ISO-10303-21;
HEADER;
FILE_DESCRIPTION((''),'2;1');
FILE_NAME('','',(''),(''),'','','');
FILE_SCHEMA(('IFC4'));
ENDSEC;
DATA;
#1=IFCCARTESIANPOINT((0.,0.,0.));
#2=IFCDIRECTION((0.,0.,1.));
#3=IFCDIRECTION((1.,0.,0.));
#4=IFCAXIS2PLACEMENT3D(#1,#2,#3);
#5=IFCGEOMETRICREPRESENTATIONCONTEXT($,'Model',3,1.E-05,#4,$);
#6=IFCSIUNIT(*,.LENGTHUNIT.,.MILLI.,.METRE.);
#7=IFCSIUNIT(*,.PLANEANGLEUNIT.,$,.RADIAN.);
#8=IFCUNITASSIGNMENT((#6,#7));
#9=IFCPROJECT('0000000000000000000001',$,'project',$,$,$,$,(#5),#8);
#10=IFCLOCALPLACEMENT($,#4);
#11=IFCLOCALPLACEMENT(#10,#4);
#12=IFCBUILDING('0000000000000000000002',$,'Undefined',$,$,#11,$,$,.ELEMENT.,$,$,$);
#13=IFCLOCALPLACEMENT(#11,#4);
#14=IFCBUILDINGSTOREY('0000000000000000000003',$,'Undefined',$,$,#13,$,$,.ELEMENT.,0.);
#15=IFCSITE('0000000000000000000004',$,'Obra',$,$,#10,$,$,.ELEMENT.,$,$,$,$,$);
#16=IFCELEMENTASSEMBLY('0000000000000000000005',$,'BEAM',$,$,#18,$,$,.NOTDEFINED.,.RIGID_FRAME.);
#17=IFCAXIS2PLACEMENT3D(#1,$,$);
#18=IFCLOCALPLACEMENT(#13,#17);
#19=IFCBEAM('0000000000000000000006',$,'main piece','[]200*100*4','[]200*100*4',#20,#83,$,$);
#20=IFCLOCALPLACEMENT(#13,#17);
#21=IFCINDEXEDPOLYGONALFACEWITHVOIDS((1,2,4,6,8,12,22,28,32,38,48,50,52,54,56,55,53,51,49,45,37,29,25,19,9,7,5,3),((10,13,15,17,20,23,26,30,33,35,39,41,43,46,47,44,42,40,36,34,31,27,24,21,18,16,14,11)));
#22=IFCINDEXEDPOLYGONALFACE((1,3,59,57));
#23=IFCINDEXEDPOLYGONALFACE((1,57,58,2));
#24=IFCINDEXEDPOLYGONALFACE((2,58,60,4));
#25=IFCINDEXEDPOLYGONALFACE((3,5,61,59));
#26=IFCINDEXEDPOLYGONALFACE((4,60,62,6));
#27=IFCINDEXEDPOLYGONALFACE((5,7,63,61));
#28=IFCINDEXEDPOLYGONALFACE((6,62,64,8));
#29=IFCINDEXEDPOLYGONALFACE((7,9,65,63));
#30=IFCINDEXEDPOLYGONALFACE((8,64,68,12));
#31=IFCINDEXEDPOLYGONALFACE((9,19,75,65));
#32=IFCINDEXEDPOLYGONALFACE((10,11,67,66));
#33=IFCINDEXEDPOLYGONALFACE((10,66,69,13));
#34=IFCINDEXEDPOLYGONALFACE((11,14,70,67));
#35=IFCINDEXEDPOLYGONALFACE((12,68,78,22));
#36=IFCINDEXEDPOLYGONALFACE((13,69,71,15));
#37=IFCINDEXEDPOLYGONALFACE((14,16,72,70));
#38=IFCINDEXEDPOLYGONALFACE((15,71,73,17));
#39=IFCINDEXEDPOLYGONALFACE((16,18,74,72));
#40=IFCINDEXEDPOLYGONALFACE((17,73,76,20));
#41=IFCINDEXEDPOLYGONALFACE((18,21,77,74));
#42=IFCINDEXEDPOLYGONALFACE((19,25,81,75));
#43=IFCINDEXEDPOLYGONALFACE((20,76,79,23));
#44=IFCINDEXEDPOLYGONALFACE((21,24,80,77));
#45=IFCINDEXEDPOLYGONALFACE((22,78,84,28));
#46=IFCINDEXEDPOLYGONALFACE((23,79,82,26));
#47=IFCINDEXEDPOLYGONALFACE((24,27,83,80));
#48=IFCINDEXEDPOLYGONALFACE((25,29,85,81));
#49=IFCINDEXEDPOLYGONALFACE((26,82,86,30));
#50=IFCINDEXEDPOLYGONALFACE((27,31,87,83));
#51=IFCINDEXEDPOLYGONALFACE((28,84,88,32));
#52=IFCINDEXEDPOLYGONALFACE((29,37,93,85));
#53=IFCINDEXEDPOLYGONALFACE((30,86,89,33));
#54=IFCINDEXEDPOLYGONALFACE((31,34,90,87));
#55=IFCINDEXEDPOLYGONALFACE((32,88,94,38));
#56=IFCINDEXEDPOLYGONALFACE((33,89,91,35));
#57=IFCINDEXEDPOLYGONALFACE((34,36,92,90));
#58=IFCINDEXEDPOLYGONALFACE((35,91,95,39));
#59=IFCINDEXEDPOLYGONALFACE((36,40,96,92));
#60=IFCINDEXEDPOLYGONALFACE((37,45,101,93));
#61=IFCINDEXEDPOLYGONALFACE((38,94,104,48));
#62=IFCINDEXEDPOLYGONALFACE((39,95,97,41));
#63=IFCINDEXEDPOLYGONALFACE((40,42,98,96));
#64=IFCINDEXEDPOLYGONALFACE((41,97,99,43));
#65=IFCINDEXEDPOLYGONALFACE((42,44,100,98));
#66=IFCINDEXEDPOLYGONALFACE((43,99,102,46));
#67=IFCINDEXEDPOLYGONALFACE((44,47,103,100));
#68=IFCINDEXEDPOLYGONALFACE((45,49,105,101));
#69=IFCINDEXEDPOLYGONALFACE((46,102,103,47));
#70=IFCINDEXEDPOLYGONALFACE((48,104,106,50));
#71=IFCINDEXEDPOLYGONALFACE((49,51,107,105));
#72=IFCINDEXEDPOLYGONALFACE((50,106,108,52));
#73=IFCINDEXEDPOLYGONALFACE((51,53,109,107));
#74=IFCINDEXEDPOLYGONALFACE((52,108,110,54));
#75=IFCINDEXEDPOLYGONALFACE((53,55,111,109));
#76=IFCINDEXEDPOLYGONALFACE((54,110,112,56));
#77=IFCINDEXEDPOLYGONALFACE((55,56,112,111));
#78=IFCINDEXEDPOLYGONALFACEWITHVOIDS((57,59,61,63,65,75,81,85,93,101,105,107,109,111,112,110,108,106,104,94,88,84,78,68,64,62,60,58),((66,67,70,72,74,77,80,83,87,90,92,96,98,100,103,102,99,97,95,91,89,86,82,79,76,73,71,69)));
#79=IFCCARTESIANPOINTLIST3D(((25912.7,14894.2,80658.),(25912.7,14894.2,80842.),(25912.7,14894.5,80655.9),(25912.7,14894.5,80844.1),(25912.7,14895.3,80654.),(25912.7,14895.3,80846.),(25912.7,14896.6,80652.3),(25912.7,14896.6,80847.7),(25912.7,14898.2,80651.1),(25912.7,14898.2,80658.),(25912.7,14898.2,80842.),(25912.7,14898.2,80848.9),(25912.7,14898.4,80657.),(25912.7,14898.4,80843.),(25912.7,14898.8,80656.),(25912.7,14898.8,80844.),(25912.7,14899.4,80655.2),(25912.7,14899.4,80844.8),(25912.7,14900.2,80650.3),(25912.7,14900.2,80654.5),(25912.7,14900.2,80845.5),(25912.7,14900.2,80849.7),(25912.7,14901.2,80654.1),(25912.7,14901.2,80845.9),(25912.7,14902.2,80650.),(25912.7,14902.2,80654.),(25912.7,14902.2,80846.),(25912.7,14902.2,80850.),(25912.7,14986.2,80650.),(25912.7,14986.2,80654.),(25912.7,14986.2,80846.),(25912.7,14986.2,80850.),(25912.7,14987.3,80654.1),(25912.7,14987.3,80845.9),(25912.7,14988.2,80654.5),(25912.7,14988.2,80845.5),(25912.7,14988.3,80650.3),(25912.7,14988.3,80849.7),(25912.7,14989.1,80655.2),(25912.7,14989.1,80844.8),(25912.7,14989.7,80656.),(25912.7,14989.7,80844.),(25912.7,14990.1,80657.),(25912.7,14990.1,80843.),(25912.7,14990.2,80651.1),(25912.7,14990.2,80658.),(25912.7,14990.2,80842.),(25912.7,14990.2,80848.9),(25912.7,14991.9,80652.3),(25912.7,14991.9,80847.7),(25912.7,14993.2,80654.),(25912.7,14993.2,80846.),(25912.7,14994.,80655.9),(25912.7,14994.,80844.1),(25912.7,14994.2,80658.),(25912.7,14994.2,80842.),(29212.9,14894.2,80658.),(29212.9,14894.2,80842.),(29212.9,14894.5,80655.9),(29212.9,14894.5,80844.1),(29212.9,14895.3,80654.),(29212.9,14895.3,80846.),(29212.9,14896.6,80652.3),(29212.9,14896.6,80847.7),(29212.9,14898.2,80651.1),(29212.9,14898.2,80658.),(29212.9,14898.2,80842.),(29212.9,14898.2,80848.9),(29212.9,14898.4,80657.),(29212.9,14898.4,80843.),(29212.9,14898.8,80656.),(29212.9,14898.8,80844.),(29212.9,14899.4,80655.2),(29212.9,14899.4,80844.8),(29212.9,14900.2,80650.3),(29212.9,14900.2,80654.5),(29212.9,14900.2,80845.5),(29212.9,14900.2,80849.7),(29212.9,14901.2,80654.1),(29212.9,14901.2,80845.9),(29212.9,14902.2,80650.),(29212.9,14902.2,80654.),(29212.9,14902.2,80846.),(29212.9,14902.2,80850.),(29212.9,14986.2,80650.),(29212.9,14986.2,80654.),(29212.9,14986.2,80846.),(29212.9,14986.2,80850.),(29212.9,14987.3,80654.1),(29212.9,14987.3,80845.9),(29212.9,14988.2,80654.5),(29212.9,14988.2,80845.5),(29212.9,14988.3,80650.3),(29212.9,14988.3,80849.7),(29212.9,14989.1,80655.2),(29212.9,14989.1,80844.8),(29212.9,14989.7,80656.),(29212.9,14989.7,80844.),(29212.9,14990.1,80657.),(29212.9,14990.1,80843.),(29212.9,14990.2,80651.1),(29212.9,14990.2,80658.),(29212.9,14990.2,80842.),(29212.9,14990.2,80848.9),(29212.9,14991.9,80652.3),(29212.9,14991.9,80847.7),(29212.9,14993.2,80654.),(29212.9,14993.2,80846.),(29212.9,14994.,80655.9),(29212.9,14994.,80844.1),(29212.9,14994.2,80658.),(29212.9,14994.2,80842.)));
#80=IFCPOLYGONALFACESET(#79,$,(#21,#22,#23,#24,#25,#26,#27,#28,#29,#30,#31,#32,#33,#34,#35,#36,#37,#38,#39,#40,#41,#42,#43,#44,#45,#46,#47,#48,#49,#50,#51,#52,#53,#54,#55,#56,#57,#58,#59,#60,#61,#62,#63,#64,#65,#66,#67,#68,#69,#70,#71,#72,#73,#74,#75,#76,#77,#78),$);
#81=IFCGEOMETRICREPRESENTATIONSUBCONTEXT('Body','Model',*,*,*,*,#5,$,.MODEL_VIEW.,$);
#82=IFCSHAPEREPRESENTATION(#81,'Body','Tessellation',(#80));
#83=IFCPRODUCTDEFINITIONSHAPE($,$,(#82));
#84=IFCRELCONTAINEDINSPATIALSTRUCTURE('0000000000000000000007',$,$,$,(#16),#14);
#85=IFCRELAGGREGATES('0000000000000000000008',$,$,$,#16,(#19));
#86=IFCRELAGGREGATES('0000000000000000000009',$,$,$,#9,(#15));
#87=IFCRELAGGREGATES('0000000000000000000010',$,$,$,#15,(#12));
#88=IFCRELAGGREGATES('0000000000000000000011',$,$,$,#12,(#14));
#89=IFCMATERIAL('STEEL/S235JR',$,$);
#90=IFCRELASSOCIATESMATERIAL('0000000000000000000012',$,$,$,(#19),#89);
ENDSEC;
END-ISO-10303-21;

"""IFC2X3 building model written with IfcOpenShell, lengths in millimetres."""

from ifc_helpers import new_model, si_unit, frame, origin_with_axes, origin_2d_with_axis, place, context, subcontext, project, spatial, hollow_rectangle, extrude, material, element, aggregate, save


model = new_model("IFC2X3")

# Units and contexts
model_context = context("Model", 3, precision=1e-05, world=origin_with_axes())
body_context = subcontext(model_context, "Body", "Model", "MODEL_VIEW")
ifc_project = project(units=[si_unit("LENGTHUNIT", "METRE", prefix="MILLI"), si_unit("PLANEANGLEUNIT", "RADIAN")], contexts=[model_context])

# Site, building, storey
site_placement = place(None, origin_with_axes())
site = spatial("IfcSite", under=ifc_project, at=site_placement, Name="Obra", CompositionType="ELEMENT")
building_placement = place(site_placement, origin_with_axes())
building = spatial("IfcBuilding", under=site, at=building_placement, Name="Undefined", CompositionType="ELEMENT")
storey_placement = place(building_placement, origin_with_axes())
storey = spatial("IfcBuildingStorey", under=building, at=storey_placement, Name="Undefined", CompositionType="ELEMENT", Elevation=0.0)

# Shared definitions
ifc_material = material(Name="STEEL/S235JR")

# Element assembly, beam
assembly_1_placement = place(storey_placement, origin_with_axes())
assembly_1 = element("IfcElementAssembly", 1, at=assembly_1_placement, inside=storey, Name="BEAM", AssemblyPlace="NOTDEFINED", PredefinedType="RIGID_FRAME")
beam_1_placement = place(assembly_1_placement, frame((25912.7, 14944.2, 80750.0), z_axis=(0.0, 0.0, 1.0), x_axis=(1.0, 0.0, 0.0)))
beam_1 = element("IfcBeam", 2, at=beam_1_placement, material=ifc_material, Name="main piece", Description="[]200*100*4", ObjectType="[]200*100*4", context=body_context, shape_type="SweptSolid", body=[
    extrude(hollow_rectangle(XDim=100.0, YDim=200.0, WallThickness=4.0, InnerFilletRadius=4.0, OuterFilletRadius=8.0, at=origin_2d_with_axis()), frame((3300.2, 0.0, 0.0), z_axis=(-1.0, 0.0, 0.0), x_axis=(0.0, -1.0, 0.0)), (0.0, 0.0, 1.0), 3300.2),
])
aggregate(assembly_1, [beam_1])

save(model, "model.ifc")
